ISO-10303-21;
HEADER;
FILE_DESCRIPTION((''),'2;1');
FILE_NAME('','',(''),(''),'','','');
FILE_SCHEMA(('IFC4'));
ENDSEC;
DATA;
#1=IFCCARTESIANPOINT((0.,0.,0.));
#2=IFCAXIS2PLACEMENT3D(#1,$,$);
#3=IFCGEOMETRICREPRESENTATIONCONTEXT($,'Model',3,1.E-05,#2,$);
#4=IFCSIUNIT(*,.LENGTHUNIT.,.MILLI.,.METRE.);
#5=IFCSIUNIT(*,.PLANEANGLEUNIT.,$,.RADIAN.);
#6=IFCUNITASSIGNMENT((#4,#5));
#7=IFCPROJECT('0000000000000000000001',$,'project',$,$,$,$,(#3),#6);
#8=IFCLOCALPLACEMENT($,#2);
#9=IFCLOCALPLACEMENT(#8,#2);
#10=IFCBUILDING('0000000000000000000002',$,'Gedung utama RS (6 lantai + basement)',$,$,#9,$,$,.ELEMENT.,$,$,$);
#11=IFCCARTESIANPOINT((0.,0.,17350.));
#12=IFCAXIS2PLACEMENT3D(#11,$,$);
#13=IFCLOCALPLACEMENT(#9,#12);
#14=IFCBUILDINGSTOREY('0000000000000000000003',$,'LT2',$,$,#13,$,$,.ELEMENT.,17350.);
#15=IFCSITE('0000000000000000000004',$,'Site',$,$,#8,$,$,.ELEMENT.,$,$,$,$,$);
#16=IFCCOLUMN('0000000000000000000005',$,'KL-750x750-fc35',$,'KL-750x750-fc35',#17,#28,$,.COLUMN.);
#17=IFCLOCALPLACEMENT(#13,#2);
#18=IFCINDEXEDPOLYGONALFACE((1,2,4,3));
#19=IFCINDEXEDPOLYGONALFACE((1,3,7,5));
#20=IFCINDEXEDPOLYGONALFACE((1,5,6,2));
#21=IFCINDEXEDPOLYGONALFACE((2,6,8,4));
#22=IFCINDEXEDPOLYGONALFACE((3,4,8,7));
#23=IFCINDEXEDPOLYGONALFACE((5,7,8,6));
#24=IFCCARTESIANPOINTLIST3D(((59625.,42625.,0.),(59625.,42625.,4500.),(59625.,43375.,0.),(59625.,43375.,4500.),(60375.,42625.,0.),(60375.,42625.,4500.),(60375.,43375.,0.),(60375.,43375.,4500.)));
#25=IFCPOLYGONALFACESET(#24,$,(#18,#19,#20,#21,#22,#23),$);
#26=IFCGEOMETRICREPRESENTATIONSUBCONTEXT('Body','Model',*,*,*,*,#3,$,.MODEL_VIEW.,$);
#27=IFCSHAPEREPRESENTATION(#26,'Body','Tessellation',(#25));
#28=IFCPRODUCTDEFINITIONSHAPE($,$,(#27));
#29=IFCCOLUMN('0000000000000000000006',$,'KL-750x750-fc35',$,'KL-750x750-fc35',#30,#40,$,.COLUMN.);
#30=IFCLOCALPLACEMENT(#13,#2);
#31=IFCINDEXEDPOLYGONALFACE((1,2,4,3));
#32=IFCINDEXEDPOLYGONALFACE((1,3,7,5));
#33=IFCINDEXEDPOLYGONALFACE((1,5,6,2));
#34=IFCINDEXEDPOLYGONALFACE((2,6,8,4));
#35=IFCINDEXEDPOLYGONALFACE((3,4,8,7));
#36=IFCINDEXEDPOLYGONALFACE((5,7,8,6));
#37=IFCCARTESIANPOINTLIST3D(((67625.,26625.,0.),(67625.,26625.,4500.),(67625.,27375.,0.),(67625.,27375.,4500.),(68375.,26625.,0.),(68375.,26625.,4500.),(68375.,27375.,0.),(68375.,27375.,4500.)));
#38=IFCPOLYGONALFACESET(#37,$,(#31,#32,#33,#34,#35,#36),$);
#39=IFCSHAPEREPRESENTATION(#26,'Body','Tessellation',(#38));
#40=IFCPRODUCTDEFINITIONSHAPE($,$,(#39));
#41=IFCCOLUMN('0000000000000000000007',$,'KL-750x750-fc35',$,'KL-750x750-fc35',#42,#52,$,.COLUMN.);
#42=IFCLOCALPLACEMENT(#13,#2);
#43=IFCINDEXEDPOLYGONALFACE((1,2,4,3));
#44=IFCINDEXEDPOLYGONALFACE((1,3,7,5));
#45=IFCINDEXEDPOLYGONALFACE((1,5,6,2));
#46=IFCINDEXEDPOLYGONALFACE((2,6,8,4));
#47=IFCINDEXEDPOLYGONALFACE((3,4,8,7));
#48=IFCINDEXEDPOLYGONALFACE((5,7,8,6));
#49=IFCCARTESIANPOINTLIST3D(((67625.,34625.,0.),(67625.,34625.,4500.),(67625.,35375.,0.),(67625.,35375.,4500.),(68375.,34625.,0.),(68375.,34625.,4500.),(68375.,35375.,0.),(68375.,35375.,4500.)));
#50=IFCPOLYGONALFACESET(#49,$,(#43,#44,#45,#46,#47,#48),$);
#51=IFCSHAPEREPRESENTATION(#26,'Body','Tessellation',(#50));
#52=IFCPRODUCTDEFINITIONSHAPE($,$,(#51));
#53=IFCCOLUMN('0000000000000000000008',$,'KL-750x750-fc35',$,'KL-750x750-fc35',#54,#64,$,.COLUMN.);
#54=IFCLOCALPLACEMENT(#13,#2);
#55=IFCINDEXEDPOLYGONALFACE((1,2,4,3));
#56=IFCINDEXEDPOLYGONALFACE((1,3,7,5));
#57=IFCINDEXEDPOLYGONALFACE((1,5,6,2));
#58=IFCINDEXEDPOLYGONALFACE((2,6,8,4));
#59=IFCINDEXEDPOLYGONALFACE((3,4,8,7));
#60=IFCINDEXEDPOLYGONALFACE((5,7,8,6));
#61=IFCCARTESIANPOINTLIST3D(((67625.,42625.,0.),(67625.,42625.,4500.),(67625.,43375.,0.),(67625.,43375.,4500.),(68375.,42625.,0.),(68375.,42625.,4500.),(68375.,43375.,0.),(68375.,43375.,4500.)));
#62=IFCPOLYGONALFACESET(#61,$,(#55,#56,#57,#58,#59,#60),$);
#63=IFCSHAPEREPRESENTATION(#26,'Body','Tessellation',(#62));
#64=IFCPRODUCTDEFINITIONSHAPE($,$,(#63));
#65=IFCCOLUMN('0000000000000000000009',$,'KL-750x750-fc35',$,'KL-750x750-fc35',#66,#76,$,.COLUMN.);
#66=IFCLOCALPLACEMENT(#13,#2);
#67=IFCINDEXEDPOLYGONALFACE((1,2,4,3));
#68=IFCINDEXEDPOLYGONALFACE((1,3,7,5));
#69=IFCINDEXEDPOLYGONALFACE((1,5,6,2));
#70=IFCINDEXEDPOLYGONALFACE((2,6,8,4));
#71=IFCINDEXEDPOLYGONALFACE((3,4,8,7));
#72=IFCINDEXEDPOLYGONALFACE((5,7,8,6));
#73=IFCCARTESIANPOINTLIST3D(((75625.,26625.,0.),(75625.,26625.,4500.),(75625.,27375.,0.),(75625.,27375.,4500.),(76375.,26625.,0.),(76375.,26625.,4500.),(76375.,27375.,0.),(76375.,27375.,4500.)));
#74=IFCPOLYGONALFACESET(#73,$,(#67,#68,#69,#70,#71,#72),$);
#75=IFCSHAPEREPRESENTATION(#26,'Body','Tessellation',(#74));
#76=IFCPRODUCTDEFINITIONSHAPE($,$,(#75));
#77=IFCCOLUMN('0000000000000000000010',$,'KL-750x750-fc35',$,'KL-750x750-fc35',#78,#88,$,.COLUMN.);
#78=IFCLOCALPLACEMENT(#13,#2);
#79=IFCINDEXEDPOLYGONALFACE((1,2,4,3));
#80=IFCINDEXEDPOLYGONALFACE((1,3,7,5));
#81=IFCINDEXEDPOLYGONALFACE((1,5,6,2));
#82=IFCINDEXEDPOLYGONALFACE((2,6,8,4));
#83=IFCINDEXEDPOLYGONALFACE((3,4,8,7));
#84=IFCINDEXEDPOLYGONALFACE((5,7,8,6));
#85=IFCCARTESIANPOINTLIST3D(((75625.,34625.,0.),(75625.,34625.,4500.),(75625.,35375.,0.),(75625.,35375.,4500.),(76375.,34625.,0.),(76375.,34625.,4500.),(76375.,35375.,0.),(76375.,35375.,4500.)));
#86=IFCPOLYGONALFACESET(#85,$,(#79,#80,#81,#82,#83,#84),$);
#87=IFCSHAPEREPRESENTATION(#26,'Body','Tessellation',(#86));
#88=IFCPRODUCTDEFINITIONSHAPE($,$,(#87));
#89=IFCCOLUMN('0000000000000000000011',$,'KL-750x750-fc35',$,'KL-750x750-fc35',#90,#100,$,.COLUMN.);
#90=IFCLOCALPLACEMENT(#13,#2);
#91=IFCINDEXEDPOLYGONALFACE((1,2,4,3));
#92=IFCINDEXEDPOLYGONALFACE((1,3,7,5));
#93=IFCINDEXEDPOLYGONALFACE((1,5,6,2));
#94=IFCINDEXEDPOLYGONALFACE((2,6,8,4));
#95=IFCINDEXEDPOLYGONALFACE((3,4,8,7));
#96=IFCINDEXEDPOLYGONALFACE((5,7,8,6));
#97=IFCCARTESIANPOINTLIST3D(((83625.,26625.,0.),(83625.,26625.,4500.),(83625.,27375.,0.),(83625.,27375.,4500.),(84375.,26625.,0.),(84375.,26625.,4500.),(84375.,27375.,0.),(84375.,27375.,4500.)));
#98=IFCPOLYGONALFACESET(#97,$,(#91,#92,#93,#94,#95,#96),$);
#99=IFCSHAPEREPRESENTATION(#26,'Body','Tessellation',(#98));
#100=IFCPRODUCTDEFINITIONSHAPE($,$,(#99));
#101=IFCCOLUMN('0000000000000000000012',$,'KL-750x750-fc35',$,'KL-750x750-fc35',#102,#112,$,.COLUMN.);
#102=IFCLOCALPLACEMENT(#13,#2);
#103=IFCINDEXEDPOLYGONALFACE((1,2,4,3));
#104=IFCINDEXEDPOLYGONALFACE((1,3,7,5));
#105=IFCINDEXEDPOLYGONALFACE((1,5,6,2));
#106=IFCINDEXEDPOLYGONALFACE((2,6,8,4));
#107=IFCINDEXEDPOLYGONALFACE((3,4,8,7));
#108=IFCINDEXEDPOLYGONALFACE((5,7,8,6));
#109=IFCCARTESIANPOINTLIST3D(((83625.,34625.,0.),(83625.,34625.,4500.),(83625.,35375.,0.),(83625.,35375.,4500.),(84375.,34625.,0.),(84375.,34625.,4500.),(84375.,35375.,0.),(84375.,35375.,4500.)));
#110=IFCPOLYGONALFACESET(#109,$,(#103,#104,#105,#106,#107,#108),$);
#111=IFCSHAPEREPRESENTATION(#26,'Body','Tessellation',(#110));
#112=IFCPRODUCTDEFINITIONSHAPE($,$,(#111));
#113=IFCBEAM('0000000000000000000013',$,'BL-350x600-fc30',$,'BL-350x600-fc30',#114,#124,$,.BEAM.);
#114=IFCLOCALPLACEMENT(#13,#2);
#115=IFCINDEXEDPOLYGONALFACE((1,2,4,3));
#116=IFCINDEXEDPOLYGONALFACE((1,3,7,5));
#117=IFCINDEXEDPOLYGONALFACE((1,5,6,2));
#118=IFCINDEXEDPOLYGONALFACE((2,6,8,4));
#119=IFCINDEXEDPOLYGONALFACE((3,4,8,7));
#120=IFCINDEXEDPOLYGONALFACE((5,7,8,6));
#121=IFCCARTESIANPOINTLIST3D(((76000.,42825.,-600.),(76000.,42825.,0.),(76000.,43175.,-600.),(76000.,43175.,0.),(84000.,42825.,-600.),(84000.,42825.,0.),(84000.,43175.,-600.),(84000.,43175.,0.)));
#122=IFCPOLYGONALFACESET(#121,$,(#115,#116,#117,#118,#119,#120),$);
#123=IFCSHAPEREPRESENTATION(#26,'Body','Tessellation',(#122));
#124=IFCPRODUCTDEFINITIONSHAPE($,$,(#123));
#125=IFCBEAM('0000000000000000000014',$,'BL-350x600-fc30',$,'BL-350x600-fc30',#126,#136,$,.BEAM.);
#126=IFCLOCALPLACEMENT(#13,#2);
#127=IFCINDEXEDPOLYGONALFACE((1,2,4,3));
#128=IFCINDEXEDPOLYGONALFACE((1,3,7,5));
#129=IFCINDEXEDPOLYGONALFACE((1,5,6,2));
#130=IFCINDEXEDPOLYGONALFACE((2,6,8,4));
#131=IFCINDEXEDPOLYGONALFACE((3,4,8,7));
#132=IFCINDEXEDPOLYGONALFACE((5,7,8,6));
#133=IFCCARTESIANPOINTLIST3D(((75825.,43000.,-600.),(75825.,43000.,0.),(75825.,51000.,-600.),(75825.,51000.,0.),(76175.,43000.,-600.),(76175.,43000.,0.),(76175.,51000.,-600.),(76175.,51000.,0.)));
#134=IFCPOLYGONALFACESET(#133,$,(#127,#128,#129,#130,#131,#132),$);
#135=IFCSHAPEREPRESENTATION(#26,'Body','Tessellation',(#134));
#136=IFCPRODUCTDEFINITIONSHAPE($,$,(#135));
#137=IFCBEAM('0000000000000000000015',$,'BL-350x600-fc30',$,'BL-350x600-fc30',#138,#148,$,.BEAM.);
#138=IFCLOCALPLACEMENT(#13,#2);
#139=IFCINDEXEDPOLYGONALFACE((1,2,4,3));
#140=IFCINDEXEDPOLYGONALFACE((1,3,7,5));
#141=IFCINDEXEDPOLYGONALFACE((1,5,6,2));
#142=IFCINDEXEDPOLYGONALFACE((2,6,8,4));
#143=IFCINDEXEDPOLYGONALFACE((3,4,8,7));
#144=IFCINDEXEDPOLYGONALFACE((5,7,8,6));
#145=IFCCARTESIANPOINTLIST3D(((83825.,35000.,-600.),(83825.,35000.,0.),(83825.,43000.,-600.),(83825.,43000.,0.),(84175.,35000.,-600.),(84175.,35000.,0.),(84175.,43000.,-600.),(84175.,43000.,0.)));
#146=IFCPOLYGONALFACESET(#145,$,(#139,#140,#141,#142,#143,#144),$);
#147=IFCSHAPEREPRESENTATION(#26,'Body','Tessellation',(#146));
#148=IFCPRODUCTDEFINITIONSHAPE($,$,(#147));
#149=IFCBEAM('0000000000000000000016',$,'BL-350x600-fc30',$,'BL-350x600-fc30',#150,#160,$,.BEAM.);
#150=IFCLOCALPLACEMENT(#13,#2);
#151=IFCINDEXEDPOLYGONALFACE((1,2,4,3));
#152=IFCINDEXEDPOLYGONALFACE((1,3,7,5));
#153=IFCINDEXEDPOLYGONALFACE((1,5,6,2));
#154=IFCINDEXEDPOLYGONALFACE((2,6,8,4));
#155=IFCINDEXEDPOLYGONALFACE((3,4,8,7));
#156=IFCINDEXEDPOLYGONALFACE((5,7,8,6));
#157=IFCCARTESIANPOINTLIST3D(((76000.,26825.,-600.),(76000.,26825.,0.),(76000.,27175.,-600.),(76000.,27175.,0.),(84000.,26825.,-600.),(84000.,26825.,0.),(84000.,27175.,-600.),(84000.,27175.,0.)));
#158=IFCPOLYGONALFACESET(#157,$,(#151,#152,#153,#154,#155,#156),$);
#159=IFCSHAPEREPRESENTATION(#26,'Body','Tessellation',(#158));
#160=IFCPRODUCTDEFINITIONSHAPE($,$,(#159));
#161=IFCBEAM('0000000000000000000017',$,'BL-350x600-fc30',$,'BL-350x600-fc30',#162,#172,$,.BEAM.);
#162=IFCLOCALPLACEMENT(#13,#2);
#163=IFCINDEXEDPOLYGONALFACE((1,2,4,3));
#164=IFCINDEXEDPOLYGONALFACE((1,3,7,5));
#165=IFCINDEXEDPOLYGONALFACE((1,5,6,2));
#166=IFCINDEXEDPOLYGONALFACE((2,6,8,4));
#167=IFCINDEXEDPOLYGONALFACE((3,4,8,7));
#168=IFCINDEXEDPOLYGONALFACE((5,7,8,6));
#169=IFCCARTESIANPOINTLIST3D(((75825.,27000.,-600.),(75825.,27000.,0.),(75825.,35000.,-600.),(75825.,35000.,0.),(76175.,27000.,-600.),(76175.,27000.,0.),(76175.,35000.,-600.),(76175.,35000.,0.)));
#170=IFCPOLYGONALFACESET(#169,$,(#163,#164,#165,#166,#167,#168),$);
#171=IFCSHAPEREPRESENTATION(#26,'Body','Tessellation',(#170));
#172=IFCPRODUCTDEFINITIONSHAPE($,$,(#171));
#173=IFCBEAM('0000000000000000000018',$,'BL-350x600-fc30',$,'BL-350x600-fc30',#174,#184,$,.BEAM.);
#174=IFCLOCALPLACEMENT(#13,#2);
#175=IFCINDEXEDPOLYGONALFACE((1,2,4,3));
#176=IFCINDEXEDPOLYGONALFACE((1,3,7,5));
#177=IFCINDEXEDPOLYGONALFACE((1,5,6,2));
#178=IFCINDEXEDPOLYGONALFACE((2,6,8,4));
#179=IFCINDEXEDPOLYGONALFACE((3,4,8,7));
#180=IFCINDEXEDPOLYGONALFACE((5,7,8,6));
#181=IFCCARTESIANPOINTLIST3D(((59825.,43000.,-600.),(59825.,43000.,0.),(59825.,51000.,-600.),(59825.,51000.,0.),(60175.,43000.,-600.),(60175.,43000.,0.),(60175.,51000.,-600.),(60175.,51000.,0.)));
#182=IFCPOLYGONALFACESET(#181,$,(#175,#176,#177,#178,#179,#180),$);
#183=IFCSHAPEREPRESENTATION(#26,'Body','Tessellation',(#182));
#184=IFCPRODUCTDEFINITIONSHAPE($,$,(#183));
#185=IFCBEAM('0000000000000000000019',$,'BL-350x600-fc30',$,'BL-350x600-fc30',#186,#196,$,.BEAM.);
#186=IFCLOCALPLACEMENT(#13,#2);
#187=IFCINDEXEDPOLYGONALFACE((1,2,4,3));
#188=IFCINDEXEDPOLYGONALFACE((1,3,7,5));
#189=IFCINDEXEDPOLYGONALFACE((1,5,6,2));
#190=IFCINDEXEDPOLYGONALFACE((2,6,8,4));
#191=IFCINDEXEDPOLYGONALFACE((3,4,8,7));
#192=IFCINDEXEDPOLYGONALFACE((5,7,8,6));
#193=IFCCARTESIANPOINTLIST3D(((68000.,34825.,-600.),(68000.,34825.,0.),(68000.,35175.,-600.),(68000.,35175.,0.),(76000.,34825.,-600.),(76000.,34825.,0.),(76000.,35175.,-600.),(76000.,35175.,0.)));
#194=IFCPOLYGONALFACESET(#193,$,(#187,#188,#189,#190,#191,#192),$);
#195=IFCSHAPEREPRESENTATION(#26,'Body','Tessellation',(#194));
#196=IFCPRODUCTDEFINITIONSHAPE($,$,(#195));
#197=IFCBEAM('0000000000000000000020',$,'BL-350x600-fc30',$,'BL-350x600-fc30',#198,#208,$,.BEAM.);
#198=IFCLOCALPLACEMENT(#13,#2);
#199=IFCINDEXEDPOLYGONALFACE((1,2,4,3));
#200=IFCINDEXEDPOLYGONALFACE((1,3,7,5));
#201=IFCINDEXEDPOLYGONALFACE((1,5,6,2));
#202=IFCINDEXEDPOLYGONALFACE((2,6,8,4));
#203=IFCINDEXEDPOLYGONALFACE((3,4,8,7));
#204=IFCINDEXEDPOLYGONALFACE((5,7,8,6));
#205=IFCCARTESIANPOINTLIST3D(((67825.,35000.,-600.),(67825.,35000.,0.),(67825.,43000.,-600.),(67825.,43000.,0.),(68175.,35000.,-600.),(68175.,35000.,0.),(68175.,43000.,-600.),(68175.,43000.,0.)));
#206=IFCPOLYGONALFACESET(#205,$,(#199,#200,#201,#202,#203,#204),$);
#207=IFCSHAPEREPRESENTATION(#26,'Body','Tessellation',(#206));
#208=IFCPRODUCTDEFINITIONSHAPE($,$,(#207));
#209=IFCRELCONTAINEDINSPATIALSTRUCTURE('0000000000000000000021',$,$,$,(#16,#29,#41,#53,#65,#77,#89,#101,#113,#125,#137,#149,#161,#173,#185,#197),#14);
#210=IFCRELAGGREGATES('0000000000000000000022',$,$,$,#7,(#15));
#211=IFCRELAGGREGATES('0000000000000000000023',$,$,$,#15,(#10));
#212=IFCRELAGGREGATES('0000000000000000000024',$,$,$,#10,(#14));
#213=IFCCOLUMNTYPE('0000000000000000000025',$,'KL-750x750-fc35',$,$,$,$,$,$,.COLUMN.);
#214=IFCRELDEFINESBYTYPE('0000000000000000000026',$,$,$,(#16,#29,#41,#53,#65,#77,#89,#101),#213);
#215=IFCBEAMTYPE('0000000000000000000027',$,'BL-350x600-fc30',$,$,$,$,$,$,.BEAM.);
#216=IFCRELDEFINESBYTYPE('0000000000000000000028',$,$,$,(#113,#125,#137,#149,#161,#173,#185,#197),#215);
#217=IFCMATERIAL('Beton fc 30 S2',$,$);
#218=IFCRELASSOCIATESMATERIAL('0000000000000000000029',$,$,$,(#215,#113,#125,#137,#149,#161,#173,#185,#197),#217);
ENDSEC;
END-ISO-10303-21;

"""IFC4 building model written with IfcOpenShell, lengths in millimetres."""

from ifc_helpers import new_model, si_unit, frame, origin, origin_2d, place, context, subcontext, project, spatial, rectangle, extrude, material, material_profile, profile_set, profile_usage, type_object, element, save


model = new_model("IFC4")

# Units and contexts
model_context = context("Model", 3, precision=1e-05, world=origin())
body_context = subcontext(model_context, "Body", "Model", "MODEL_VIEW")
ifc_project = project(units=[si_unit("LENGTHUNIT", "METRE", prefix="MILLI"), si_unit("PLANEANGLEUNIT", "RADIAN")], contexts=[model_context])

# Site, building, storey
site_placement = place(None, origin())
site = spatial("IfcSite", under=ifc_project, at=site_placement, Name="Site", CompositionType="ELEMENT")
building_placement = place(site_placement, origin())
building = spatial("IfcBuilding", under=site, at=building_placement, Name="Gedung utama RS (6 lantai + basement)", CompositionType="ELEMENT")
storey_placement = place(building_placement, frame((0.0, 0.0, 17350.0)))
storey = spatial("IfcBuildingStorey", under=building, at=storey_placement, Name="LT2", CompositionType="ELEMENT", Elevation=17350.0)

# Columns
ifc_material_profile_1 = material_profile(None, rectangle(XDim=750.0, YDim=750.0, at=origin_2d()), Name="KL-750x750-fc35")
ifc_profile_set_1 = profile_set([ifc_material_profile_1], Name="KL-750x750-fc35")
ifc_profile_usage_1 = profile_usage(ifc_profile_set_1, cardinal=5)
column_type = type_object("IfcColumnType", Name="KL-750x750-fc35", PredefinedType="COLUMN", material=ifc_profile_set_1)
for number, where, z_axis, x_axis, name in (
    (1, (60000.0, 43000.0, 0.0), (0.0, 0.0, 1.0), (1.0, 0.0, 0.0), "KL-750x750-fc35"),
    (2, (68000.0, 27000.0, 0.0), (0.0, 0.0, 1.0), (1.0, 0.0, 0.0), "KL-750x750-fc35"),
    (3, (68000.0, 35000.0, 0.0), (0.0, 0.0, 1.0), (1.0, 0.0, 0.0), "KL-750x750-fc35"),
    (4, (68000.0, 43000.0, 0.0), (0.0, 0.0, 1.0), (1.0, 0.0, 0.0), "KL-750x750-fc35"),
    (5, (76000.0, 27000.0, 0.0), (0.0, 0.0, 1.0), (1.0, 0.0, 0.0), "KL-750x750-fc35"),
    (6, (76000.0, 35000.0, 0.0), (0.0, 0.0, 1.0), (1.0, 0.0, 0.0), "KL-750x750-fc35"),
    (7, (84000.0, 27000.0, 0.0), (0.0, 0.0, 1.0), (1.0, 0.0, 0.0), "KL-750x750-fc35"),
    (8, (84000.0, 35000.0, 0.0), (0.0, 0.0, 1.0), (1.0, 0.0, 0.0), "KL-750x750-fc35"),
):
    element("IfcColumn", number, at=place(storey_placement, frame(where, z_axis=z_axis, x_axis=x_axis)), inside=storey, type_object=column_type, material=ifc_profile_usage_1, Name=name, ObjectType="KL-750x750-fc35", PredefinedType="COLUMN", context=body_context, shape_type="SweptSolid", body=[
        extrude(rectangle(XDim=750.0, YDim=750.0, at=origin_2d()), origin(), (0.0, 0.0, 1.0), 4500.0),
    ])

# Beams
ifc_material_1 = material(Name="Beton fc 30 S2")
ifc_material_profile_2 = material_profile(ifc_material_1, rectangle(XDim=350.0, YDim=600.0, at=origin_2d()), Name="BL-350x600-fc30")
ifc_profile_set_2 = profile_set([ifc_material_profile_2], Name="BL-350x600-fc30")
ifc_profile_usage_2 = profile_usage(ifc_profile_set_2, cardinal=8)
beam_type = type_object("IfcBeamType", Name="BL-350x600-fc30", PredefinedType="BEAM", material=ifc_profile_set_2)
beam_1_placement = place(storey_placement, frame((76000.0, 43000.0, -300.0)))
element("IfcBeam", 9, at=beam_1_placement, inside=storey, type_object=beam_type, material=ifc_profile_usage_2, Name="BL-350x600-fc30", ObjectType="BL-350x600-fc30", PredefinedType="BEAM", context=body_context, shape_type="SweptSolid", body=[
    extrude(rectangle(XDim=350.0, YDim=600.0, at=origin_2d()), frame((0.0, 0.0, 0.0), z_axis=(1.0, 0.0, 0.0), x_axis=(0.0, 1.0, 0.0)), (0.0, 0.0, 1.0), 8000.0),
])
for number, where, name in (
    (10, (76000.0, 43000.0, -300.0), "BL-350x600-fc30"),
    (11, (84000.0, 35000.0, -300.0), "BL-350x600-fc30"),
):
    element("IfcBeam", number, at=place(storey_placement, frame(where)), inside=storey, type_object=beam_type, material=ifc_profile_usage_2, Name=name, ObjectType="BL-350x600-fc30", PredefinedType="BEAM", context=body_context, shape_type="SweptSolid", body=[
        extrude(rectangle(XDim=350.0, YDim=600.0, at=origin_2d()), frame((0.0, 0.0, 0.0), z_axis=(0.0, 1.0, 0.0), x_axis=(-1.0, 0.0, 0.0)), (0.0, 0.0, 1.0), 8000.0),
    ])
beam_2_placement = place(storey_placement, frame((76000.0, 27000.0, -300.0)))
element("IfcBeam", 12, at=beam_2_placement, inside=storey, type_object=beam_type, material=ifc_profile_usage_2, Name="BL-350x600-fc30", ObjectType="BL-350x600-fc30", PredefinedType="BEAM", context=body_context, shape_type="SweptSolid", body=[
    extrude(rectangle(XDim=350.0, YDim=600.0, at=origin_2d()), frame((0.0, 0.0, 0.0), z_axis=(1.0, 0.0, 0.0), x_axis=(0.0, 1.0, 0.0)), (0.0, 0.0, 1.0), 8000.0),
])
for number, where, name in (
    (13, (76000.0, 27000.0, -300.0), "BL-350x600-fc30"),
    (14, (60000.0, 43000.0, -300.0), "BL-350x600-fc30"),
):
    element("IfcBeam", number, at=place(storey_placement, frame(where)), inside=storey, type_object=beam_type, material=ifc_profile_usage_2, Name=name, ObjectType="BL-350x600-fc30", PredefinedType="BEAM", context=body_context, shape_type="SweptSolid", body=[
        extrude(rectangle(XDim=350.0, YDim=600.0, at=origin_2d()), frame((0.0, 0.0, 0.0), z_axis=(0.0, 1.0, 0.0), x_axis=(-1.0, 0.0, 0.0)), (0.0, 0.0, 1.0), 8000.0),
    ])
beam_3_placement = place(storey_placement, frame((68000.0, 35000.0, -300.0)))
element("IfcBeam", 15, at=beam_3_placement, inside=storey, type_object=beam_type, material=ifc_profile_usage_2, Name="BL-350x600-fc30", ObjectType="BL-350x600-fc30", PredefinedType="BEAM", context=body_context, shape_type="SweptSolid", body=[
    extrude(rectangle(XDim=350.0, YDim=600.0, at=origin_2d()), frame((0.0, 0.0, 0.0), z_axis=(1.0, 0.0, 0.0), x_axis=(0.0, 1.0, 0.0)), (0.0, 0.0, 1.0), 8000.0),
])
beam_4_placement = place(storey_placement, frame((68000.0, 35000.0, -300.0)))
element("IfcBeam", 16, at=beam_4_placement, inside=storey, type_object=beam_type, material=ifc_profile_usage_2, Name="BL-350x600-fc30", ObjectType="BL-350x600-fc30", PredefinedType="BEAM", context=body_context, shape_type="SweptSolid", body=[
    extrude(rectangle(XDim=350.0, YDim=600.0, at=origin_2d()), frame((0.0, 0.0, 0.0), z_axis=(0.0, 1.0, 0.0), x_axis=(-1.0, 0.0, 0.0)), (0.0, 0.0, 1.0), 8000.0),
])

save(model, "model.ifc")
